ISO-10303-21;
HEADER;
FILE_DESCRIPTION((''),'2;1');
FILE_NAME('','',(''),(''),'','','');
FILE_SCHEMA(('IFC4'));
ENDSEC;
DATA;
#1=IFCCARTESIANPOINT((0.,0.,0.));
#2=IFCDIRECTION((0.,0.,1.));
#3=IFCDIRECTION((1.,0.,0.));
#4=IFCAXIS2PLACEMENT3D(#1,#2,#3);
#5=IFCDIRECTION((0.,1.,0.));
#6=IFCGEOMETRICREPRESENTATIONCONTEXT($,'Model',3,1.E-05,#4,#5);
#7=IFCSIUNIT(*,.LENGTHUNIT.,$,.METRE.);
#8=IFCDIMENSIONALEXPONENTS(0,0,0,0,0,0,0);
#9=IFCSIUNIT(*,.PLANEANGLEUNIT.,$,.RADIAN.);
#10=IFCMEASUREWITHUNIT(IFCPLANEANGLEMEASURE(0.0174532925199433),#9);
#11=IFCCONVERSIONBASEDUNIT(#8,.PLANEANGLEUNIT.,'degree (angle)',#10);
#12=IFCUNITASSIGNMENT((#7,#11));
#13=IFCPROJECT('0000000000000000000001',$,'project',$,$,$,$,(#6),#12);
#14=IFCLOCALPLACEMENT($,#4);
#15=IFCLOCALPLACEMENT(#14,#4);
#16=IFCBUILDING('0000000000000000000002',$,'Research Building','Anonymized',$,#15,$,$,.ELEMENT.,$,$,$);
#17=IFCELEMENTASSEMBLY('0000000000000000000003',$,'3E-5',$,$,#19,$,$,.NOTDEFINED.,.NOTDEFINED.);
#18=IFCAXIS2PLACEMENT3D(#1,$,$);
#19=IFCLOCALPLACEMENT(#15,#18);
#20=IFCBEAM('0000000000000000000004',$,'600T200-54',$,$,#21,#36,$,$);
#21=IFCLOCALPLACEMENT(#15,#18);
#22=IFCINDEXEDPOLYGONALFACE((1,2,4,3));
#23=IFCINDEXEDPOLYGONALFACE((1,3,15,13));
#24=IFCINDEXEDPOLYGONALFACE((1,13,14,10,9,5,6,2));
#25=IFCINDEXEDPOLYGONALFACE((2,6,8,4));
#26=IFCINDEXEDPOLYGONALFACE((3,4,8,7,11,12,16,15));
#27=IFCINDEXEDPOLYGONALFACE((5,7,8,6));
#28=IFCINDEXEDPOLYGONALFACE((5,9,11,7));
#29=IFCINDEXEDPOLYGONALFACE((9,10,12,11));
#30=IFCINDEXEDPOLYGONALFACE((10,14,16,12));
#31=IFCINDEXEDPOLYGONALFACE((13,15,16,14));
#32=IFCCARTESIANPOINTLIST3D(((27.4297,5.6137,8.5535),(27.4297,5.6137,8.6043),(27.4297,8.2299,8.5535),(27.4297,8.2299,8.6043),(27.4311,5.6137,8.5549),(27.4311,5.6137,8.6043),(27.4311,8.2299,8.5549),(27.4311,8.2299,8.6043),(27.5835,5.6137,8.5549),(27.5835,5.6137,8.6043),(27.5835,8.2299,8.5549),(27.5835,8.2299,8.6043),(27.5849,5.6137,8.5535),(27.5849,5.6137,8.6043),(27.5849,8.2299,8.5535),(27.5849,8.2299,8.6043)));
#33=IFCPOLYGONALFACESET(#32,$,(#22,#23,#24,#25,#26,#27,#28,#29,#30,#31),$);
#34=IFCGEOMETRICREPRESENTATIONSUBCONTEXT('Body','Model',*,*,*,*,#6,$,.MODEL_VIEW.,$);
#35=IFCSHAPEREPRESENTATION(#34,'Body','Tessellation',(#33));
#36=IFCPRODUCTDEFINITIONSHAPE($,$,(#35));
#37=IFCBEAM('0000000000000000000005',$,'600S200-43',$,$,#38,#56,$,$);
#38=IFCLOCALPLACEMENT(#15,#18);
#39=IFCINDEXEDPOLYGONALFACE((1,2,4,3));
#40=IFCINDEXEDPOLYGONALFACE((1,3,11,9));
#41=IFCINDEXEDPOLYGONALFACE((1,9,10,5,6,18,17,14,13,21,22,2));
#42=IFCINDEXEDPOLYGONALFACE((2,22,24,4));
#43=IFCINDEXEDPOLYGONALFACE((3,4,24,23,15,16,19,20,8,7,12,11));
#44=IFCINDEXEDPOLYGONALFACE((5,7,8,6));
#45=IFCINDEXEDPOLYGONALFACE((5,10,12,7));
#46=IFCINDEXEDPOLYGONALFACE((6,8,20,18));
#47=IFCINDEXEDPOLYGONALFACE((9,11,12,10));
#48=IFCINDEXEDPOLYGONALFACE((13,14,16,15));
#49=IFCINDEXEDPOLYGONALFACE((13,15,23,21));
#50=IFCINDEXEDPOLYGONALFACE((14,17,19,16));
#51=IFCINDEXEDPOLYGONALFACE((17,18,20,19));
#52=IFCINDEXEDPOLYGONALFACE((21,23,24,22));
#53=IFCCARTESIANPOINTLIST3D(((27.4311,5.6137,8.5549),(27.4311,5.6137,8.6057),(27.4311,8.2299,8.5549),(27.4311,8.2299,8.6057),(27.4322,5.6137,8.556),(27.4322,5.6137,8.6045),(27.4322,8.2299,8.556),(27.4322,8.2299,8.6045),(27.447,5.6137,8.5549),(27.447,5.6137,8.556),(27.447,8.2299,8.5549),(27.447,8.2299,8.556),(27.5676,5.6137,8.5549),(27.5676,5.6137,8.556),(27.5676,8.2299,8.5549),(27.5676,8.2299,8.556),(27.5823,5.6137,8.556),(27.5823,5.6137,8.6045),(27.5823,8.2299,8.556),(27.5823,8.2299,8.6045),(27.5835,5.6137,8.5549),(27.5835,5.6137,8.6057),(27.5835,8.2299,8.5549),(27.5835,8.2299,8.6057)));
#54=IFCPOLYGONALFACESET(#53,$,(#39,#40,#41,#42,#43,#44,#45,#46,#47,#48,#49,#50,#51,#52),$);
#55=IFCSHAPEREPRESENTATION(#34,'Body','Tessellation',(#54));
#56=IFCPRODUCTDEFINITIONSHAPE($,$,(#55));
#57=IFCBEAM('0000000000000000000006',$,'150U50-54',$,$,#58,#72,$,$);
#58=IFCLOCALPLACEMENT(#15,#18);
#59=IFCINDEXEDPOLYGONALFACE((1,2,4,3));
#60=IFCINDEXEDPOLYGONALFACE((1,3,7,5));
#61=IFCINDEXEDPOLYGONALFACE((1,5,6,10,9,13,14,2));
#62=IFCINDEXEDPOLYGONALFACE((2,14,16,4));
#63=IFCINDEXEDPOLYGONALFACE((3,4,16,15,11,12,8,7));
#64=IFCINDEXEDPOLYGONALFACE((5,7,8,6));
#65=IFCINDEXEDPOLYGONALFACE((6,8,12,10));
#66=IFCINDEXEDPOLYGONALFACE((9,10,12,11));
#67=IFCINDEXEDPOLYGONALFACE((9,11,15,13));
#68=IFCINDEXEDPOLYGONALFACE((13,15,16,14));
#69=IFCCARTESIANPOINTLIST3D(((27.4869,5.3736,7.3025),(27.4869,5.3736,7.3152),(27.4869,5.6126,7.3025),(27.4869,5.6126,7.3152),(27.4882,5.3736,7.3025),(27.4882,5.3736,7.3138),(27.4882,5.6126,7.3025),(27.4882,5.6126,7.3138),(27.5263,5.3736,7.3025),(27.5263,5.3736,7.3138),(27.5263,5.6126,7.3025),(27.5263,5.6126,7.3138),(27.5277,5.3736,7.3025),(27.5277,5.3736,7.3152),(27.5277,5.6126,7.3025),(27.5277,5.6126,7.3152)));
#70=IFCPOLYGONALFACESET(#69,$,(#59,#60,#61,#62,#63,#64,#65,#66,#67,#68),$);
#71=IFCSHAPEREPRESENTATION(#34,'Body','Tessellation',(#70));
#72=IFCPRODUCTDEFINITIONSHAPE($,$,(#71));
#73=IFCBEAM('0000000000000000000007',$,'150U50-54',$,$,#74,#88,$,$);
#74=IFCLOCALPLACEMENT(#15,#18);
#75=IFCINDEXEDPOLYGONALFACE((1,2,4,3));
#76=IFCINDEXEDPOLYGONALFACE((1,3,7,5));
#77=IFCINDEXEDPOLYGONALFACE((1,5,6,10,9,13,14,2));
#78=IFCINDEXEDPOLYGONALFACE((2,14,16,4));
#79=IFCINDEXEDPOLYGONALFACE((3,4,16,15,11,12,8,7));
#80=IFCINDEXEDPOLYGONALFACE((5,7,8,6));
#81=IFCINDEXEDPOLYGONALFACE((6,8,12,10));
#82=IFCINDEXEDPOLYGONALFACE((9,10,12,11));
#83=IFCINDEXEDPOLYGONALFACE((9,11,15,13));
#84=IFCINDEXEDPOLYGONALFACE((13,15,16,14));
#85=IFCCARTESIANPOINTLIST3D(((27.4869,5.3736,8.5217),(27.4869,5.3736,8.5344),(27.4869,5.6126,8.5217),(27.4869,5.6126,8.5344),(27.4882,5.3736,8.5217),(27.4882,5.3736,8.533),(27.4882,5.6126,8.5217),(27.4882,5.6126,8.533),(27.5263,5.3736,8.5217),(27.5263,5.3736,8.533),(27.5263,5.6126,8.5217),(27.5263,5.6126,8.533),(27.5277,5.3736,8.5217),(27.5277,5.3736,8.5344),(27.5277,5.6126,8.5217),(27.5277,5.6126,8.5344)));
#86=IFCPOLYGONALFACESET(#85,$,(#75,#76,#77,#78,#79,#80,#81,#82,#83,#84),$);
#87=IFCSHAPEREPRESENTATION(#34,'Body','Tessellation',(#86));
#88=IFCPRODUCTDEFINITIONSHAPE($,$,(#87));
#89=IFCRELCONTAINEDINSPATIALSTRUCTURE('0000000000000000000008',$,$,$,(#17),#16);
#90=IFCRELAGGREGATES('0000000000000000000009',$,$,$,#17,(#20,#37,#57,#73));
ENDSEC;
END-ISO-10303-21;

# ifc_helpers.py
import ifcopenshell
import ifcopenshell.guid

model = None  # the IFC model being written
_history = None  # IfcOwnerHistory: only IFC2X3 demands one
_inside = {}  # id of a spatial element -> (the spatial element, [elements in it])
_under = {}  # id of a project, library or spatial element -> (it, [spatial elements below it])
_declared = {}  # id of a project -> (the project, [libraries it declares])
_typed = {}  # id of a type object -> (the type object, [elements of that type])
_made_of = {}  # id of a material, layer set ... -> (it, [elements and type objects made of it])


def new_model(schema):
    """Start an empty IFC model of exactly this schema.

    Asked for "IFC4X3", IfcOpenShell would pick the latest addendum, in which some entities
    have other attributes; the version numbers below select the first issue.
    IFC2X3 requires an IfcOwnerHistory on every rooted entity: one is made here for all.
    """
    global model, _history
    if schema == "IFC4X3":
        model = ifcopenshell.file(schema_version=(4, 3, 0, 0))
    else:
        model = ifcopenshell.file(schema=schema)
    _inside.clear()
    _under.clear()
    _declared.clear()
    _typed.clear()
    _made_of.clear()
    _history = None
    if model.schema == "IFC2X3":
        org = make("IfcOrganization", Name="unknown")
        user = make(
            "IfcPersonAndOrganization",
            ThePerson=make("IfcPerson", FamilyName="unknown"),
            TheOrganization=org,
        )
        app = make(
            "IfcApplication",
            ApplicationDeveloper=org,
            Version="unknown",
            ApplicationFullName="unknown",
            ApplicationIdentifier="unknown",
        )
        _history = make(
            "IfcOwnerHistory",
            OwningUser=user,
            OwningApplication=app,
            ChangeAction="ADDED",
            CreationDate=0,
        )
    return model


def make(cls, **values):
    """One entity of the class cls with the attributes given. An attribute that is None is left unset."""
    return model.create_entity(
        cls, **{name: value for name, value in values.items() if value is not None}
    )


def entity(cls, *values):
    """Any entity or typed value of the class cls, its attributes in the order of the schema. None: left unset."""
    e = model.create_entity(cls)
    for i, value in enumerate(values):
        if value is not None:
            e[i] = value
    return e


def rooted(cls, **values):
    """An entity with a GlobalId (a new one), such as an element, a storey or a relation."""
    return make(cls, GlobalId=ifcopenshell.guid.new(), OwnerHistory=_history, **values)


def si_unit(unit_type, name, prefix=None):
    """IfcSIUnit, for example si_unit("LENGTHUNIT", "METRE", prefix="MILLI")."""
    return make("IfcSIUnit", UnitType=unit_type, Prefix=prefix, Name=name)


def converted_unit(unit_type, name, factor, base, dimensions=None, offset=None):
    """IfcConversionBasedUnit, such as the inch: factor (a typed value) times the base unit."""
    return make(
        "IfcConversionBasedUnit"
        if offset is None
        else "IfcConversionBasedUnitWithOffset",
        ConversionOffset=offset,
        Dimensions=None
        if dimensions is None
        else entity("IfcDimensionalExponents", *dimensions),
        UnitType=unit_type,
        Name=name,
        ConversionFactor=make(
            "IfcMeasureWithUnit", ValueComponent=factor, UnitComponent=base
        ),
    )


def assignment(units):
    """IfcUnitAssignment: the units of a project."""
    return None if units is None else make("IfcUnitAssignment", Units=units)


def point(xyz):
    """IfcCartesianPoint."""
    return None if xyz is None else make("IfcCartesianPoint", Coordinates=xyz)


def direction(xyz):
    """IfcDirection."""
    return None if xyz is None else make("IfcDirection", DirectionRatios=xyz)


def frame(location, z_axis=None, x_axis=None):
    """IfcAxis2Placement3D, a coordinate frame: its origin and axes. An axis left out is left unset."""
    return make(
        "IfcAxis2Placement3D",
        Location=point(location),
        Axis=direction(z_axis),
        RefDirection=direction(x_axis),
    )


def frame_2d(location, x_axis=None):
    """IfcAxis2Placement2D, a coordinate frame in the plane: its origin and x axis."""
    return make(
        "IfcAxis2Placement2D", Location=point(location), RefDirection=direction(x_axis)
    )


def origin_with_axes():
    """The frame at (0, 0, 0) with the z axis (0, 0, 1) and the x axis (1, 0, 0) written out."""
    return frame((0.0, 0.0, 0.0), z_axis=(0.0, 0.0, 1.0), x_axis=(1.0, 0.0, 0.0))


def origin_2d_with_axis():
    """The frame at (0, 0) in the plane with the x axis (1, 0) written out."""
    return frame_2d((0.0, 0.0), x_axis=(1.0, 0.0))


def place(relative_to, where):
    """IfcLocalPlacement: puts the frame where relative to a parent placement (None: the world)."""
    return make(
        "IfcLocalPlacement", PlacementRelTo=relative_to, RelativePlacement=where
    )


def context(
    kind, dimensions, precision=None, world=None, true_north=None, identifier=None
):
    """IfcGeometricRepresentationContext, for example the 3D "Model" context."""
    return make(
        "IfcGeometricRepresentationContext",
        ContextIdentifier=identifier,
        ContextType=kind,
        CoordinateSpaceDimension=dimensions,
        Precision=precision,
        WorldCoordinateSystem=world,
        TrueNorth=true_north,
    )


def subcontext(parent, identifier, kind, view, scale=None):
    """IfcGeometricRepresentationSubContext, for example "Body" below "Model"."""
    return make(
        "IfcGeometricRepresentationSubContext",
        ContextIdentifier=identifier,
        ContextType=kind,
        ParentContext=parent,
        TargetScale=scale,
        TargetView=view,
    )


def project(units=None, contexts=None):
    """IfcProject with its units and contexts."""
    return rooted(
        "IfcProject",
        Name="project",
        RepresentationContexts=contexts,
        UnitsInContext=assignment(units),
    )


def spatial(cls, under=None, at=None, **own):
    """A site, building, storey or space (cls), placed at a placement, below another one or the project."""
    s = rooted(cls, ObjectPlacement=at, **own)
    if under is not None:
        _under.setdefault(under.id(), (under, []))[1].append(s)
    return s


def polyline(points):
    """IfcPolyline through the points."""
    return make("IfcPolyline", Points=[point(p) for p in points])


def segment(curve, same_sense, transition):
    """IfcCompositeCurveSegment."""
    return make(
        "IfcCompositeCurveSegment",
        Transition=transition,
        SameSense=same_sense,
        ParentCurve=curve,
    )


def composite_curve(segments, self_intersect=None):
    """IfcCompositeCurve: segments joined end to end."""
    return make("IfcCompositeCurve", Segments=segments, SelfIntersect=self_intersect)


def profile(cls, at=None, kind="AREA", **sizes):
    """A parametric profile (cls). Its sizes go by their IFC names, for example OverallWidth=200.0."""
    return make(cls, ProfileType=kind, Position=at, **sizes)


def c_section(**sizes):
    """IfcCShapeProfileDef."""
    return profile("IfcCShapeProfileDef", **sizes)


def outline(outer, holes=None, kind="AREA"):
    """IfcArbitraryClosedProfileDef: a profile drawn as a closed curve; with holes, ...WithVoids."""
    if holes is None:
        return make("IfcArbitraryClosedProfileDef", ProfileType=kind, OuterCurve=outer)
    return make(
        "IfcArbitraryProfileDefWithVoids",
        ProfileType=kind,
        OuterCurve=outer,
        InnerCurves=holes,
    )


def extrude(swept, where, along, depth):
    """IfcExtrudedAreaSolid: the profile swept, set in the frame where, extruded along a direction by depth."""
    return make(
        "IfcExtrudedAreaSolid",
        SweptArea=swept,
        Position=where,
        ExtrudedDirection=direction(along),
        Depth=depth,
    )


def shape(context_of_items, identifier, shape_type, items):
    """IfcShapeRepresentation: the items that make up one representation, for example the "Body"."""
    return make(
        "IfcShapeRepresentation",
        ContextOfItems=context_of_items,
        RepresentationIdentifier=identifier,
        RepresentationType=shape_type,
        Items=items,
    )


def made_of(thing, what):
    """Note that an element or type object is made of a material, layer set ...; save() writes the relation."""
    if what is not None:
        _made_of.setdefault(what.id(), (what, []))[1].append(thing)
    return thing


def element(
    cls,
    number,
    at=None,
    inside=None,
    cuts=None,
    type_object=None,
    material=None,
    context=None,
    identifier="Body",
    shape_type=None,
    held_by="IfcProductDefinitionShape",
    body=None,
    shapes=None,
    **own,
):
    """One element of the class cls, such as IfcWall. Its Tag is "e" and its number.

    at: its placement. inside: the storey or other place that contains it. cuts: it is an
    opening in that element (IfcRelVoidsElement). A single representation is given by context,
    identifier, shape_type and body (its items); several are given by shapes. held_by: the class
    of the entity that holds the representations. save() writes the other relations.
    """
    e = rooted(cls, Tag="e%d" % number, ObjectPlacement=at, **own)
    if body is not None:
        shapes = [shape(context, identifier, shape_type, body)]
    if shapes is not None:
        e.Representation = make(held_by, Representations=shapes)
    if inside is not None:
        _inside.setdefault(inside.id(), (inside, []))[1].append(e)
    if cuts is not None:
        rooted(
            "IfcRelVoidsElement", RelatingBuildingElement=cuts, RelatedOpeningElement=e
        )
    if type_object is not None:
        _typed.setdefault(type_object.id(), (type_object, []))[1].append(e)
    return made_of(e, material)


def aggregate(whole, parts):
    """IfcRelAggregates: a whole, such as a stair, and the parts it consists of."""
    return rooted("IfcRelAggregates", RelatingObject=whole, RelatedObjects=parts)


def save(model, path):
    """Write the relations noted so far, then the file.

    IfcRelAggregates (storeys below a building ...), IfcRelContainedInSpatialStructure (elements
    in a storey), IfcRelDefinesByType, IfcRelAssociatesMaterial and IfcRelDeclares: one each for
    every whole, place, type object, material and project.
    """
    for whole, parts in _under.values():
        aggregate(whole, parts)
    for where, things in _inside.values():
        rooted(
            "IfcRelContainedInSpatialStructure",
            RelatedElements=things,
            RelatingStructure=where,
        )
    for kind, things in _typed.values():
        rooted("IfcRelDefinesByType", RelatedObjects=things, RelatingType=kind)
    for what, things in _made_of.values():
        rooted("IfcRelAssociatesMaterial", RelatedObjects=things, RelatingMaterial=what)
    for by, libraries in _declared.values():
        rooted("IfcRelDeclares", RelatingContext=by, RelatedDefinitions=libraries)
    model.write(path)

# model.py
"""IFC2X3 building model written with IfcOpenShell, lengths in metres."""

from ifc_helpers import new_model, entity, si_unit, converted_unit, direction, frame, origin_with_axes, origin_2d_with_axis, place, context, subcontext, project, spatial, polyline, segment, composite_curve, c_section, outline, extrude, element, aggregate, save


model = new_model("IFC2X3")

# Units and contexts
model_context = context("Model", 3, precision=1e-05, world=origin_with_axes(), true_north=direction((0.0, 1.0, 0.0)))
body_context = subcontext(model_context, "Body", "Model", "MODEL_VIEW")
ifc_project = project(units=[si_unit("LENGTHUNIT", "METRE"), converted_unit("PLANEANGLEUNIT", "degree (angle)", entity("IfcPlaneAngleMeasure", 0.0174532925199433), si_unit("PLANEANGLEUNIT", "RADIAN"), dimensions=[0, 0, 0, 0, 0, 0, 0])], contexts=[model_context])

# Building
placement = place(None, origin_with_axes())
building_placement = place(placement, origin_with_axes())
building = spatial("IfcBuilding", at=building_placement, Name="Research Building", Description="Anonymized", CompositionType="ELEMENT")

# Element assembly, beams
assembly_placement = place(building_placement, origin_with_axes())
assembly = element("IfcElementAssembly", 1, at=assembly_placement, inside=building, Name="3E-5", AssemblyPlace="NOTDEFINED", PredefinedType="NOTDEFINED")
beam_1_placement = place(assembly_placement, frame((27.5073, 5.6137, 8.5788), z_axis=(0.0, 1.0, 0.0), x_axis=(0.0, 0.0, 1.0)))
beam_1 = element("IfcBeam", 2, at=beam_1_placement, Name="600T200-54", context=body_context, shape_type="SweptSolid", body=[
    extrude(outline(composite_curve([segment(polyline([(-0.0254, -0.0776), (-0.0254, 0.0776), (0.0254, 0.0776), (0.0254, 0.0762), (-0.024, 0.0762), (-0.024, -0.0762), (0.0254, -0.0762), (0.0254, -0.0776), (-0.0254, -0.0776)]), True, "CONTINUOUS")], self_intersect=False)), frame((0.0, 0.0, 0.0), z_axis=(0.0, 0.0, 1.0), x_axis=(1.0, 0.0, 0.0)), (0.0, 0.0, 1.0), 2.6162),
])
beam_2_placement = place(assembly_placement, frame((27.5073, 8.2299, 8.5803), z_axis=(0.0, -1.0, 0.0), x_axis=(0.0, 0.0, -1.0)))
beam_2 = element("IfcBeam", 3, at=beam_2_placement, Name="600S200-43", context=body_context, shape_type="SweptSolid", body=[
    extrude(c_section(Depth=0.1524, Width=0.0508, WallThickness=0.0011, Girth=0.0159, at=origin_2d_with_axis()), frame((0.0, 0.0, 0.0), z_axis=(0.0, 0.0, 1.0), x_axis=(1.0, 0.0, 0.0)), (0.0, 0.0, 1.0), 2.6162),
])
beam_3_placement = place(assembly_placement, frame((27.5073, 5.6126, 7.3088), z_axis=(0.0, -1.0, 0.0), x_axis=(0.0, 0.0, -1.0)))
beam_3 = element("IfcBeam", 4, at=beam_3_placement, Name="150U50-54", context=body_context, shape_type="SweptSolid", body=[
    extrude(outline(composite_curve([segment(polyline([(-0.0063, -0.0204), (-0.0063, 0.0204), (0.0064, 0.0204), (0.0064, 0.019), (-0.005, 0.019), (-0.005, -0.019), (0.0064, -0.019), (0.0064, -0.0204), (-0.0063, -0.0204)]), True, "CONTINUOUS")], self_intersect=False)), frame((0.0, 0.0, 0.0), z_axis=(0.0, 0.0, 1.0), x_axis=(1.0, 0.0, 0.0)), (0.0, 0.0, 1.0), 0.239),
])
beam_4_placement = place(assembly_placement, frame((27.5073, 5.6126, 8.5281), z_axis=(0.0, -1.0, 0.0), x_axis=(0.0, 0.0, -1.0)))
beam_4 = element("IfcBeam", 5, at=beam_4_placement, Name="150U50-54", context=body_context, shape_type="SweptSolid", body=[
    extrude(outline(composite_curve([segment(polyline([(-0.0063, -0.0204), (-0.0063, 0.0204), (0.0064, 0.0204), (0.0064, 0.019), (-0.005, 0.019), (-0.005, -0.019), (0.0064, -0.019), (0.0064, -0.0204), (-0.0063, -0.0204)]), True, "CONTINUOUS")], self_intersect=False)), frame((0.0, 0.0, 0.0), z_axis=(0.0, 0.0, 1.0), x_axis=(1.0, 0.0, 0.0)), (0.0, 0.0, 1.0), 0.239),
])
aggregate(assembly, [beam_1, beam_2, beam_3, beam_4])

save(model, "model.ifc")
